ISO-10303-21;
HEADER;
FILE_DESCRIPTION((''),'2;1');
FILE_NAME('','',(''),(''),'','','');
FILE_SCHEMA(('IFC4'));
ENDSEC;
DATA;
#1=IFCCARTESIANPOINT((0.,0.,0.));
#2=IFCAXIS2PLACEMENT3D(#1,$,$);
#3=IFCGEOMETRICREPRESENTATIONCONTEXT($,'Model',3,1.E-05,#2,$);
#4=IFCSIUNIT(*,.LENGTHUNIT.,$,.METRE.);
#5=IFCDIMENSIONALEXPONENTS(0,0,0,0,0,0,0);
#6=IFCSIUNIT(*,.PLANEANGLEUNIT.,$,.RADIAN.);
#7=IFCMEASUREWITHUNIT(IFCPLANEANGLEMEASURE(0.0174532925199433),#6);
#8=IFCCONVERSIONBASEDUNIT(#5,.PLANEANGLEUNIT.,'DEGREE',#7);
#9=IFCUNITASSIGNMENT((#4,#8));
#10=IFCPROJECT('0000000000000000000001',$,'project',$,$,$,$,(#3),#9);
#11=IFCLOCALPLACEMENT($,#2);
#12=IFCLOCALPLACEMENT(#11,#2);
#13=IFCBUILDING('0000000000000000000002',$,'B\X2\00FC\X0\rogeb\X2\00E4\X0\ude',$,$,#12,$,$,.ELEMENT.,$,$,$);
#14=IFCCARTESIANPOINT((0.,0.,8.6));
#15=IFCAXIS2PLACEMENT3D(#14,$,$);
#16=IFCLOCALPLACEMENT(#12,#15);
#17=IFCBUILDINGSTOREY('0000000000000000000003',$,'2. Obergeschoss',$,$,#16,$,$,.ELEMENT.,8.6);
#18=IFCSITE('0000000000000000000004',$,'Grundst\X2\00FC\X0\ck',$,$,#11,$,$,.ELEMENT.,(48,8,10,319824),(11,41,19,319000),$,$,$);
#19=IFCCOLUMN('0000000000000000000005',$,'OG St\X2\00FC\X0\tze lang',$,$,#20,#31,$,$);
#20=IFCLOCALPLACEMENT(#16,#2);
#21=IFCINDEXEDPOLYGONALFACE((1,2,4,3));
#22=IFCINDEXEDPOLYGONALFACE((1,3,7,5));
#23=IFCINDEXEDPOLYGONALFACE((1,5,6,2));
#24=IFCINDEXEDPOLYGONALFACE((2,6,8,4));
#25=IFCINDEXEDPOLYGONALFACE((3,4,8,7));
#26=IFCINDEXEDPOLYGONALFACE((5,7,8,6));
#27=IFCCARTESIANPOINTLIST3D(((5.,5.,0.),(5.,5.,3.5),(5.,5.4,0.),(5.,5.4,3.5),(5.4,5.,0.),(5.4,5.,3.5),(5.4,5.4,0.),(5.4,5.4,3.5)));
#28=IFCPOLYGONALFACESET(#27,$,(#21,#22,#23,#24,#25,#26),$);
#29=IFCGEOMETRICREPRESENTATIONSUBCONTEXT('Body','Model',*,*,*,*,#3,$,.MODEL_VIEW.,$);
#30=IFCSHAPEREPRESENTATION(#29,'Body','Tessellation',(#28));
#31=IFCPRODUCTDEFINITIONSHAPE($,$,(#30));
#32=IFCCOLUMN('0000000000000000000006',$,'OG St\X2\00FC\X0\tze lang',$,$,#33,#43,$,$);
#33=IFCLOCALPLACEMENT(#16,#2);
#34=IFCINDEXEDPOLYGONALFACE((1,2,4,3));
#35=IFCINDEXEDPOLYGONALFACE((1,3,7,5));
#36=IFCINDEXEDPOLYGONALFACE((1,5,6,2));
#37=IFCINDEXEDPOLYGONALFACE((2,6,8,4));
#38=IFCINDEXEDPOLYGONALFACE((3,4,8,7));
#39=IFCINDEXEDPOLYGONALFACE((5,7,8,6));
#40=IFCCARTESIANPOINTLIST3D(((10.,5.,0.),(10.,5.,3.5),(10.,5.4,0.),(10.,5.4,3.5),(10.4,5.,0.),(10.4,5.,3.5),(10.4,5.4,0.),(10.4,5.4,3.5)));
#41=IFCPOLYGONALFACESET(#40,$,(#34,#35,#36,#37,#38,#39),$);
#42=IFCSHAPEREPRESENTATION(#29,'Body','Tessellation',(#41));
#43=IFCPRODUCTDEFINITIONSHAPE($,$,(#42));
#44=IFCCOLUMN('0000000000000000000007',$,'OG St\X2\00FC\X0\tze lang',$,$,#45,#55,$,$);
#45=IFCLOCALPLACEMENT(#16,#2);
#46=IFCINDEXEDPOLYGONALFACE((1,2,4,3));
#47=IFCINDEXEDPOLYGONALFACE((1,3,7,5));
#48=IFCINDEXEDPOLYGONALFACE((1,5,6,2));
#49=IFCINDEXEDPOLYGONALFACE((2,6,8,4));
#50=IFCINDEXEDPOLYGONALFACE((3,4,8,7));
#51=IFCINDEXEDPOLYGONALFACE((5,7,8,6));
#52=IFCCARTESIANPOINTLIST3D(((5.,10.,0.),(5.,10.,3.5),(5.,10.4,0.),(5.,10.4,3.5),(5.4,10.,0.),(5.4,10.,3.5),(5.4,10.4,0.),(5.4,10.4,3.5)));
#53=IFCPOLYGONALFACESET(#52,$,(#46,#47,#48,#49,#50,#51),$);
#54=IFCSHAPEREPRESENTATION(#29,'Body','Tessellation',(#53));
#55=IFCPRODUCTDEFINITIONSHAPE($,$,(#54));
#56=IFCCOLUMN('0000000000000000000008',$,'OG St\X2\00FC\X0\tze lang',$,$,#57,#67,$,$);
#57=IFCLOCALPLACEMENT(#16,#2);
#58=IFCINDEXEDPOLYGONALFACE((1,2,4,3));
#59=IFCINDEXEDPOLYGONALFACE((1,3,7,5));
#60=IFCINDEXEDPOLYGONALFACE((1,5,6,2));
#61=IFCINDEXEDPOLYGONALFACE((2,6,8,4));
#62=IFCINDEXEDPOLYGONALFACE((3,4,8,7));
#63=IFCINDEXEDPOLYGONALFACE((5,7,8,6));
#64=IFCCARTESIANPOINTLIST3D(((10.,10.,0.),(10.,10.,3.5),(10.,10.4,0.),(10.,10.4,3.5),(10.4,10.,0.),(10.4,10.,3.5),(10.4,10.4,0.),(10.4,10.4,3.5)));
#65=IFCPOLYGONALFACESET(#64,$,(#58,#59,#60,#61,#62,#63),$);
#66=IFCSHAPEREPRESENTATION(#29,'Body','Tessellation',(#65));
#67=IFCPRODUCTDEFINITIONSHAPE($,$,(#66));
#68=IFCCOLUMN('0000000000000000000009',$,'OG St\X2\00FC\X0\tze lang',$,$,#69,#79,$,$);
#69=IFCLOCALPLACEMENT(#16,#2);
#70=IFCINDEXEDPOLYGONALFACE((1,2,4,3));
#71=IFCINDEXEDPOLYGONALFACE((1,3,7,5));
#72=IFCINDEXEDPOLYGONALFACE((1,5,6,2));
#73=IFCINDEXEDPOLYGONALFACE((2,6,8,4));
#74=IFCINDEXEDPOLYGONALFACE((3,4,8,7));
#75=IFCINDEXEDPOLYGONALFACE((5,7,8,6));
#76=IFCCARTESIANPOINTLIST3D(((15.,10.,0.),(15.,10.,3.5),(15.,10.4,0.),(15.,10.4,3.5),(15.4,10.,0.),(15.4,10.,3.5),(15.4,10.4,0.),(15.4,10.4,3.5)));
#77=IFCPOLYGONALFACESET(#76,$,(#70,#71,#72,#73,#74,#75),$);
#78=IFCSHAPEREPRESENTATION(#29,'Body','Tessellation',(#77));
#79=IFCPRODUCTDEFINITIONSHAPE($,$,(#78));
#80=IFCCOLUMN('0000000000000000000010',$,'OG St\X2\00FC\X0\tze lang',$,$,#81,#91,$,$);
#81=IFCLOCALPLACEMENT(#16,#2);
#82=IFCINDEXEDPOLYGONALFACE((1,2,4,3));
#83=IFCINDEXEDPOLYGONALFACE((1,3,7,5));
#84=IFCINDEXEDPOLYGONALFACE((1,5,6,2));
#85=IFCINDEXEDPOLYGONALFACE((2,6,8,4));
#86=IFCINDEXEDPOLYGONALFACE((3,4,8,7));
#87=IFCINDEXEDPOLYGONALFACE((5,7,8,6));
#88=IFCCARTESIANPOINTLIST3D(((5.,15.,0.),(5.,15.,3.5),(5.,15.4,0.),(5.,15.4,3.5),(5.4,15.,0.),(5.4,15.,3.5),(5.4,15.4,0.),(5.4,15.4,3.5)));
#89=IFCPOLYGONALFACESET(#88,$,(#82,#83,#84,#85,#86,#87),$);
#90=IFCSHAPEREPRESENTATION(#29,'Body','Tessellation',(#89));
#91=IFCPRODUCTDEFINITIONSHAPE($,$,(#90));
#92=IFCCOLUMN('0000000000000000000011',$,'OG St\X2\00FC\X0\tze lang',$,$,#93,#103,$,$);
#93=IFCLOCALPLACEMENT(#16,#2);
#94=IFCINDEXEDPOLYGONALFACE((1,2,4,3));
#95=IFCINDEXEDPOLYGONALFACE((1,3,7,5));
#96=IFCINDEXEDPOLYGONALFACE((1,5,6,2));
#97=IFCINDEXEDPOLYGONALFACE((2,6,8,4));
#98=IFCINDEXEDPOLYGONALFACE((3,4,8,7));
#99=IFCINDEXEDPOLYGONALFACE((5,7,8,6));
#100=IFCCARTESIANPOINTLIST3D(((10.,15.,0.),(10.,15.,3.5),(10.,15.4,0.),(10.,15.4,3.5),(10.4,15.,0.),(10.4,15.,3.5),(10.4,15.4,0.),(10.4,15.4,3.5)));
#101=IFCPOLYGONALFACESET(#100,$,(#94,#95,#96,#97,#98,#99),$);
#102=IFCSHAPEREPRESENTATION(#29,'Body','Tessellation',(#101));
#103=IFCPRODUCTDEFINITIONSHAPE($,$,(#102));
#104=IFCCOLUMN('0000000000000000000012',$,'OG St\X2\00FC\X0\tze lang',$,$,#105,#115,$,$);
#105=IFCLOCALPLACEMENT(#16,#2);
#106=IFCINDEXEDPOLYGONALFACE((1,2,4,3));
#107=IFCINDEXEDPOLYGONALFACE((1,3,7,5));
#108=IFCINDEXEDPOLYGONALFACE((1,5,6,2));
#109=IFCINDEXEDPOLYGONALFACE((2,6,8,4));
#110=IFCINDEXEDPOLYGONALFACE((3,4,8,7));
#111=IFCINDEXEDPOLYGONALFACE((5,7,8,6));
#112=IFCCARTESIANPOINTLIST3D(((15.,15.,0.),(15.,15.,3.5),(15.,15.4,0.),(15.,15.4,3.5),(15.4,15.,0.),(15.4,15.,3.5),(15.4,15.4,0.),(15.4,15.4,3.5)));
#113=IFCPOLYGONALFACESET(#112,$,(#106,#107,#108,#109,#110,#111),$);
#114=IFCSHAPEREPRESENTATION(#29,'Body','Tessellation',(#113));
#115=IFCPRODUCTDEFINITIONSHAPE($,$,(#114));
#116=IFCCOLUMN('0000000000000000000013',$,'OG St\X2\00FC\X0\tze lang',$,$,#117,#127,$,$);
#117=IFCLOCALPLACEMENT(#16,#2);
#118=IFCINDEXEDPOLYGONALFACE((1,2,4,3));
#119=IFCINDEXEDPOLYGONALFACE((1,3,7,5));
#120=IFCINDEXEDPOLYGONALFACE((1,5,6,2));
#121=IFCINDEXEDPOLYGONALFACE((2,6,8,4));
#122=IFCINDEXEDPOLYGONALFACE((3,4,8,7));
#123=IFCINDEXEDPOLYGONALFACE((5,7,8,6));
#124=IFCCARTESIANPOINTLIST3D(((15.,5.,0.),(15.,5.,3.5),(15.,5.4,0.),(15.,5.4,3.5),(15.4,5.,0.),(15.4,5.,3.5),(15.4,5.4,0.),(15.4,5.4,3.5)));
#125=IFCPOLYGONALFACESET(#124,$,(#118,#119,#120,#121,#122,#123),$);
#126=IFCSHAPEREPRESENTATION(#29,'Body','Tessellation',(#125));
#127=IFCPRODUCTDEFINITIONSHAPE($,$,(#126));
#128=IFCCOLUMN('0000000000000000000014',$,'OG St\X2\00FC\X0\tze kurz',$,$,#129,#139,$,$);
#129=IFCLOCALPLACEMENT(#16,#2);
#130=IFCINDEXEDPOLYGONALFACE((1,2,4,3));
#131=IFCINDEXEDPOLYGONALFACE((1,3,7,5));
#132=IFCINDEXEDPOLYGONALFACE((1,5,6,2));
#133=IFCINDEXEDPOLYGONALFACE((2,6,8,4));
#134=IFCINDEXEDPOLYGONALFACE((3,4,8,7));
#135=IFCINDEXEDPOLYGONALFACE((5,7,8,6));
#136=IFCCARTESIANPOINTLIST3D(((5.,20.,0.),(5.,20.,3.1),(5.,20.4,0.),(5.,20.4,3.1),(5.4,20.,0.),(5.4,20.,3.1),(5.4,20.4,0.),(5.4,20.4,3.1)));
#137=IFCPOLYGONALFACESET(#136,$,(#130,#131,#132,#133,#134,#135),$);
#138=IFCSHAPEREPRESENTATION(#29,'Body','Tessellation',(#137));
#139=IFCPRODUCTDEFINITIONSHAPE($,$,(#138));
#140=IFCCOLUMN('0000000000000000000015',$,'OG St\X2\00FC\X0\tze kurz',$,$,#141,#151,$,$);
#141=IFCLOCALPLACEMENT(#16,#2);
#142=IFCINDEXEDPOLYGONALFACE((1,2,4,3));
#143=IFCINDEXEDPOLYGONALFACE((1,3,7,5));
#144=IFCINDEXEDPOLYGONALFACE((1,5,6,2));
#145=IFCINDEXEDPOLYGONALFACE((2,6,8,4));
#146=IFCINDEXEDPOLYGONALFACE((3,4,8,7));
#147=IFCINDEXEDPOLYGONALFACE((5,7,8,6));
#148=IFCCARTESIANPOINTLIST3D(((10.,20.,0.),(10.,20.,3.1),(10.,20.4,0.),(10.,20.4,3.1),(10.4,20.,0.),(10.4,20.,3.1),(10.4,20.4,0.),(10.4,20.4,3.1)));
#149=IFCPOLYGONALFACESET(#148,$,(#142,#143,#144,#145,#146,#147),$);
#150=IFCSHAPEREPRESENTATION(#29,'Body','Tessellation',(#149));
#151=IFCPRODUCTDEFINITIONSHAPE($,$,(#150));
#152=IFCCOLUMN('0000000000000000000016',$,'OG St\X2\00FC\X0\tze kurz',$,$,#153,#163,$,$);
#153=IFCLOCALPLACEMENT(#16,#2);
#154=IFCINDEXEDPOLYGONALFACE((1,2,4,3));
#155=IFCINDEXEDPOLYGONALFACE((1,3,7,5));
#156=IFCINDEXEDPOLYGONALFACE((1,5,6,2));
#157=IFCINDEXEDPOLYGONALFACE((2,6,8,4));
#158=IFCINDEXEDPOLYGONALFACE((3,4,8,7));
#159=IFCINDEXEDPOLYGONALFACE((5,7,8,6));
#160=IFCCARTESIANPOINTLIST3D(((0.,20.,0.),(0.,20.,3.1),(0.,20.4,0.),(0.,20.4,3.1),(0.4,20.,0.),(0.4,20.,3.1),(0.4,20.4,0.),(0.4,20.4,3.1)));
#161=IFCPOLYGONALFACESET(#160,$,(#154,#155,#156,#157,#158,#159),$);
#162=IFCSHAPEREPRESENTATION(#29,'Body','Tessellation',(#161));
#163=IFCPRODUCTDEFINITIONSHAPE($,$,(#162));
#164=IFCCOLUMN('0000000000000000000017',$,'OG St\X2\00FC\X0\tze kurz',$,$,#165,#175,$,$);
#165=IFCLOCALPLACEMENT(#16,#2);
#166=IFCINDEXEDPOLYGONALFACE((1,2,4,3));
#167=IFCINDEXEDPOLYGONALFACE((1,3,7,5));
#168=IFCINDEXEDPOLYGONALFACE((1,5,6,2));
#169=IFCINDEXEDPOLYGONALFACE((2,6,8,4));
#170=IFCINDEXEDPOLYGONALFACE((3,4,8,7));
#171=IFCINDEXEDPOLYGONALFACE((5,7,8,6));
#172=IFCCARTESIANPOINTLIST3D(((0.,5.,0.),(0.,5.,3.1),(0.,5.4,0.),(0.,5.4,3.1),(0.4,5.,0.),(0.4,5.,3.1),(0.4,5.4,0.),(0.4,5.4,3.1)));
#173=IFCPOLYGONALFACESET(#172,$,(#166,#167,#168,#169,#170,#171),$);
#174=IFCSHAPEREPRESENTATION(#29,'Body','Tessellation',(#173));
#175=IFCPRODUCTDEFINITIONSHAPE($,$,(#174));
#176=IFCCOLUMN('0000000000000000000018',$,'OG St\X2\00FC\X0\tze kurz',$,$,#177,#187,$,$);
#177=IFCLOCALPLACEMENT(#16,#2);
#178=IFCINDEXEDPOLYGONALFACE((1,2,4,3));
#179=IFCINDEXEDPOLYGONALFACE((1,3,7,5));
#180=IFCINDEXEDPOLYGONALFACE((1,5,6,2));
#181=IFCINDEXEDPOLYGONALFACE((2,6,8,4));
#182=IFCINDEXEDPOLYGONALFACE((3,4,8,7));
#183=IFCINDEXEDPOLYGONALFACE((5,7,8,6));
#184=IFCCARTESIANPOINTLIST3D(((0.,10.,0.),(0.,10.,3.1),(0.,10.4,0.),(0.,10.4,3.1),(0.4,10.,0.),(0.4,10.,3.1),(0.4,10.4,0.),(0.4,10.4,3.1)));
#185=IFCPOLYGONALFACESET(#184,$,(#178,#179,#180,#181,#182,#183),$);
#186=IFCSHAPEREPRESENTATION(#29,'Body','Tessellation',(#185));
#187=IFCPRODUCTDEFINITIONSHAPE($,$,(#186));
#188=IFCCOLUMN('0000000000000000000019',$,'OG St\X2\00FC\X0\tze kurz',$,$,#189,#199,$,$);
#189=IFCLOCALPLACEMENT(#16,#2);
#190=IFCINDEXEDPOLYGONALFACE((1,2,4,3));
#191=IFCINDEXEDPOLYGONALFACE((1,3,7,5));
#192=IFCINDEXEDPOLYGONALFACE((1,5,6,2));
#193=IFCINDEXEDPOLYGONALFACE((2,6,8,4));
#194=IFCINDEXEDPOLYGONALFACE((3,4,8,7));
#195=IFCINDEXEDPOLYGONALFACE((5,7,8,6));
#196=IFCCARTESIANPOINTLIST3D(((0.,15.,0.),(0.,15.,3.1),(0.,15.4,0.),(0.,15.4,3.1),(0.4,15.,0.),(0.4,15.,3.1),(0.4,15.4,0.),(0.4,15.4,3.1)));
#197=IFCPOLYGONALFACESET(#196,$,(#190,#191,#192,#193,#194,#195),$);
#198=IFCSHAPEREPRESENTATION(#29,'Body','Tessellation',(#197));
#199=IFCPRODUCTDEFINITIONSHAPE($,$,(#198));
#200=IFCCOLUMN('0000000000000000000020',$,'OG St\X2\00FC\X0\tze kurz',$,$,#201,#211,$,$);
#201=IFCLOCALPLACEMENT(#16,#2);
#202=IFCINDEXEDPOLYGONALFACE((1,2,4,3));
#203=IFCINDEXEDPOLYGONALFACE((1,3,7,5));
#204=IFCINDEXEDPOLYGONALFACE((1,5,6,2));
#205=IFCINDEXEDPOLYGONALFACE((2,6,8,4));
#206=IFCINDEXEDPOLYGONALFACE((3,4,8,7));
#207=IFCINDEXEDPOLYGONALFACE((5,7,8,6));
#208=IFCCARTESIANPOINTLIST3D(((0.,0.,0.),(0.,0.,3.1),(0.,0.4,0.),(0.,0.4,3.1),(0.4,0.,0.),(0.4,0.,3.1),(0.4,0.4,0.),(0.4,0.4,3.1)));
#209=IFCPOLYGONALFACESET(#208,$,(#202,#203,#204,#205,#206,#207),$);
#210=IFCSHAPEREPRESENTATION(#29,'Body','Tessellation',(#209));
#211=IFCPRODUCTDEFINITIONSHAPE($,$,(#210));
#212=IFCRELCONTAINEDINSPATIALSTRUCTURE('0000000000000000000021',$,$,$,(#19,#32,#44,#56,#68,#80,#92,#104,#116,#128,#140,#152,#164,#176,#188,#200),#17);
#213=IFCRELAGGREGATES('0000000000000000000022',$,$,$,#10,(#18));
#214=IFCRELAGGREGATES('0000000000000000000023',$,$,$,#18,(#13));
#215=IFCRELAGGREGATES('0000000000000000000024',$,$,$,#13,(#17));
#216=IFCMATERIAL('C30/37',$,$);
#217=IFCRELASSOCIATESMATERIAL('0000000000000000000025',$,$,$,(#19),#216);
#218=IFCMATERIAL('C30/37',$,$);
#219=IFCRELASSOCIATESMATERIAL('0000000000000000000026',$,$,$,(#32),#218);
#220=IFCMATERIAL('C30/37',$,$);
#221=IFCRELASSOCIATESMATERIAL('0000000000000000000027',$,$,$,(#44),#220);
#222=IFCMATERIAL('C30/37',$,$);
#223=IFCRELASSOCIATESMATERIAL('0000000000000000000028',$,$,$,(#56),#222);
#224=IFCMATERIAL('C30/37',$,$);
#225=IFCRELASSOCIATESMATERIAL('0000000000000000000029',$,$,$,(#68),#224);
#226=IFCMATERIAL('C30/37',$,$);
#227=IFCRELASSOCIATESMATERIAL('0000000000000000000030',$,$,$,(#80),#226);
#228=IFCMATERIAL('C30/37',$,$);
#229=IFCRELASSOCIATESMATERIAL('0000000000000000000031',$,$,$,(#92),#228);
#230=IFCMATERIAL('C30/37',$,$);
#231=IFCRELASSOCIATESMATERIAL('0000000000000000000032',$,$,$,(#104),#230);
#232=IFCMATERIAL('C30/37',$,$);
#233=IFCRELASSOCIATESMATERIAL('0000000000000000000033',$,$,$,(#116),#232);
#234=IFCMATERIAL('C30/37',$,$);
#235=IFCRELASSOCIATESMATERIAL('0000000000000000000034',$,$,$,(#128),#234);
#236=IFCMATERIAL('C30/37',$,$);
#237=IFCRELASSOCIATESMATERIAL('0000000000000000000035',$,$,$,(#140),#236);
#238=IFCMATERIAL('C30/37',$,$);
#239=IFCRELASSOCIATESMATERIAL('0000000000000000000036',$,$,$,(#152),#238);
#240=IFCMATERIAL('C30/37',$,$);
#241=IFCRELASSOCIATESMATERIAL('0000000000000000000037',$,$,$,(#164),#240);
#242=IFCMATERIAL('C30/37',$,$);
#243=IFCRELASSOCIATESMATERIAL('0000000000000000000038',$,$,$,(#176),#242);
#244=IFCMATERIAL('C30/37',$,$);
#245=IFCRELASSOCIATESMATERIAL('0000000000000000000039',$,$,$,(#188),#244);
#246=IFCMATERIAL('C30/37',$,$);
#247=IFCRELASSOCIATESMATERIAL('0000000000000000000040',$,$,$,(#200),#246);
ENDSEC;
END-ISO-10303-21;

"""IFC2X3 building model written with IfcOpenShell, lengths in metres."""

from ifc_helpers import new_model, entity, si_unit, converted_unit, frame, frame_2d, origin, origin_with_axes, place, context, subcontext, project, spatial, rectangle, extrude, material, element, save


model = new_model("IFC2X3")

# Units and contexts
model_context = context("Model", 3, precision=1e-05, world=origin())
body_context = subcontext(model_context, "Body", "Model", "MODEL_VIEW")
ifc_project = project(units=[si_unit("LENGTHUNIT", "METRE"), converted_unit("PLANEANGLEUNIT", "DEGREE", entity("IfcPlaneAngleMeasure", 0.0174532925199433), si_unit("PLANEANGLEUNIT", "RADIAN"), dimensions=[0, 0, 0, 0, 0, 0, 0])], contexts=[model_context])

# Site, building, storey
site_placement = place(None, origin())
site = spatial("IfcSite", under=ifc_project, at=site_placement, Name="Grundstück", CompositionType="ELEMENT", RefLatitude=(48, 8, 10, 319824), RefLongitude=(11, 41, 19, 319000))
building_placement = place(site_placement, origin())
building = spatial("IfcBuilding", under=site, at=building_placement, Name="Bürogebäude", CompositionType="ELEMENT")
storey_placement = place(building_placement, frame((0.0, 0.0, 8.6)))
storey = spatial("IfcBuildingStorey", under=building, at=storey_placement, Name="2. Obergeschoss", CompositionType="ELEMENT", Elevation=8.6)

# Columns
ifc_material_1 = material(Name="C30/37")
column_1_placement = place(storey_placement, frame((5.0, 5.0, 0.0)))
element("IfcColumn", 1, at=column_1_placement, inside=storey, material=ifc_material_1, Name="OG Stütze lang", context=body_context, shape_type="SweptSolid", body=[
    extrude(rectangle(XDim=0.4, YDim=0.4, at=frame_2d((0.2, 0.2), x_axis=(1.0, 0.0))), origin_with_axes(), (0.0, 0.0, 1.0), 3.5),
])
ifc_material_2 = material(Name="C30/37")
column_2_placement = place(storey_placement, frame((10.0, 5.0, 0.0)))
element("IfcColumn", 2, at=column_2_placement, inside=storey, material=ifc_material_2, Name="OG Stütze lang", context=body_context, shape_type="SweptSolid", body=[
    extrude(rectangle(XDim=0.4, YDim=0.4, at=frame_2d((0.2, 0.2), x_axis=(1.0, 0.0))), origin_with_axes(), (0.0, 0.0, 1.0), 3.5),
])
ifc_material_3 = material(Name="C30/37")
column_3_placement = place(storey_placement, frame((5.0, 10.0, 0.0)))
element("IfcColumn", 3, at=column_3_placement, inside=storey, material=ifc_material_3, Name="OG Stütze lang", context=body_context, shape_type="SweptSolid", body=[
    extrude(rectangle(XDim=0.4, YDim=0.4, at=frame_2d((0.2, 0.2), x_axis=(1.0, 0.0))), origin_with_axes(), (0.0, 0.0, 1.0), 3.5),
])
ifc_material_4 = material(Name="C30/37")
column_4_placement = place(storey_placement, frame((10.0, 10.0, 0.0)))
element("IfcColumn", 4, at=column_4_placement, inside=storey, material=ifc_material_4, Name="OG Stütze lang", context=body_context, shape_type="SweptSolid", body=[
    extrude(rectangle(XDim=0.4, YDim=0.4, at=frame_2d((0.2, 0.2), x_axis=(1.0, 0.0))), origin_with_axes(), (0.0, 0.0, 1.0), 3.5),
])
ifc_material_5 = material(Name="C30/37")
column_5_placement = place(storey_placement, frame((15.0, 10.0, 0.0)))
element("IfcColumn", 5, at=column_5_placement, inside=storey, material=ifc_material_5, Name="OG Stütze lang", context=body_context, shape_type="SweptSolid", body=[
    extrude(rectangle(XDim=0.4, YDim=0.4, at=frame_2d((0.2, 0.2), x_axis=(1.0, 0.0))), origin_with_axes(), (0.0, 0.0, 1.0), 3.5),
])
ifc_material_6 = material(Name="C30/37")
column_6_placement = place(storey_placement, frame((5.0, 15.0, 0.0)))
element("IfcColumn", 6, at=column_6_placement, inside=storey, material=ifc_material_6, Name="OG Stütze lang", context=body_context, shape_type="SweptSolid", body=[
    extrude(rectangle(XDim=0.4, YDim=0.4, at=frame_2d((0.2, 0.2), x_axis=(1.0, 0.0))), origin_with_axes(), (0.0, 0.0, 1.0), 3.5),
])
ifc_material_7 = material(Name="C30/37")
column_7_placement = place(storey_placement, frame((10.0, 15.0, 0.0)))
element("IfcColumn", 7, at=column_7_placement, inside=storey, material=ifc_material_7, Name="OG Stütze lang", context=body_context, shape_type="SweptSolid", body=[
    extrude(rectangle(XDim=0.4, YDim=0.4, at=frame_2d((0.2, 0.2), x_axis=(1.0, 0.0))), origin_with_axes(), (0.0, 0.0, 1.0), 3.5),
])
ifc_material_8 = material(Name="C30/37")
column_8_placement = place(storey_placement, frame((15.0, 15.0, 0.0)))
element("IfcColumn", 8, at=column_8_placement, inside=storey, material=ifc_material_8, Name="OG Stütze lang", context=body_context, shape_type="SweptSolid", body=[
    extrude(rectangle(XDim=0.4, YDim=0.4, at=frame_2d((0.2, 0.2), x_axis=(1.0, 0.0))), origin_with_axes(), (0.0, 0.0, 1.0), 3.5),
])
ifc_material_9 = material(Name="C30/37")
column_9_placement = place(storey_placement, frame((15.0, 5.0, 0.0)))
element("IfcColumn", 9, at=column_9_placement, inside=storey, material=ifc_material_9, Name="OG Stütze lang", context=body_context, shape_type="SweptSolid", body=[
    extrude(rectangle(XDim=0.4, YDim=0.4, at=frame_2d((0.2, 0.2), x_axis=(1.0, 0.0))), origin_with_axes(), (0.0, 0.0, 1.0), 3.5),
])
ifc_material_10 = material(Name="C30/37")
column_10_placement = place(storey_placement, frame((5.0, 20.0, 0.0)))
element("IfcColumn", 10, at=column_10_placement, inside=storey, material=ifc_material_10, Name="OG Stütze kurz", context=body_context, shape_type="SweptSolid", body=[
    extrude(rectangle(XDim=0.4, YDim=0.4, at=frame_2d((0.2, 0.2), x_axis=(1.0, 0.0))), origin_with_axes(), (0.0, 0.0, 1.0), 3.1),
])
ifc_material_11 = material(Name="C30/37")
column_11_placement = place(storey_placement, frame((10.0, 20.0, 0.0)))
element("IfcColumn", 11, at=column_11_placement, inside=storey, material=ifc_material_11, Name="OG Stütze kurz", context=body_context, shape_type="SweptSolid", body=[
    extrude(rectangle(XDim=0.4, YDim=0.4, at=frame_2d((0.2, 0.2), x_axis=(1.0, 0.0))), origin_with_axes(), (0.0, 0.0, 1.0), 3.1),
])
ifc_material_12 = material(Name="C30/37")
column_12_placement = place(storey_placement, frame((0.0, 20.0, 0.0)))
element("IfcColumn", 12, at=column_12_placement, inside=storey, material=ifc_material_12, Name="OG Stütze kurz", context=body_context, shape_type="SweptSolid", body=[
    extrude(rectangle(XDim=0.4, YDim=0.4, at=frame_2d((0.2, 0.2), x_axis=(1.0, 0.0))), origin_with_axes(), (0.0, 0.0, 1.0), 3.1),
])
ifc_material_13 = material(Name="C30/37")
column_13_placement = place(storey_placement, frame((0.0, 5.0, 0.0)))
element("IfcColumn", 13, at=column_13_placement, inside=storey, material=ifc_material_13, Name="OG Stütze kurz", context=body_context, shape_type="SweptSolid", body=[
    extrude(rectangle(XDim=0.4, YDim=0.4, at=frame_2d((0.2, 0.2), x_axis=(1.0, 0.0))), origin_with_axes(), (0.0, 0.0, 1.0), 3.1),
])
ifc_material_14 = material(Name="C30/37")
column_14_placement = place(storey_placement, frame((0.0, 10.0, 0.0)))
element("IfcColumn", 14, at=column_14_placement, inside=storey, material=ifc_material_14, Name="OG Stütze kurz", context=body_context, shape_type="SweptSolid", body=[
    extrude(rectangle(XDim=0.4, YDim=0.4, at=frame_2d((0.2, 0.2), x_axis=(1.0, 0.0))), origin_with_axes(), (0.0, 0.0, 1.0), 3.1),
])
ifc_material_15 = material(Name="C30/37")
column_15_placement = place(storey_placement, frame((0.0, 15.0, 0.0)))
element("IfcColumn", 15, at=column_15_placement, inside=storey, material=ifc_material_15, Name="OG Stütze kurz", context=body_context, shape_type="SweptSolid", body=[
    extrude(rectangle(XDim=0.4, YDim=0.4, at=frame_2d((0.2, 0.2), x_axis=(1.0, 0.0))), origin_with_axes(), (0.0, 0.0, 1.0), 3.1),
])
ifc_material_16 = material(Name="C30/37")
column_16_placement = place(storey_placement, origin())
element("IfcColumn", 16, at=column_16_placement, inside=storey, material=ifc_material_16, Name="OG Stütze kurz", context=body_context, shape_type="SweptSolid", body=[
    extrude(rectangle(XDim=0.4, YDim=0.4, at=frame_2d((0.2, 0.2), x_axis=(1.0, 0.0))), origin_with_axes(), (0.0, 0.0, 1.0), 3.1),
])

save(model, "model.ifc")
